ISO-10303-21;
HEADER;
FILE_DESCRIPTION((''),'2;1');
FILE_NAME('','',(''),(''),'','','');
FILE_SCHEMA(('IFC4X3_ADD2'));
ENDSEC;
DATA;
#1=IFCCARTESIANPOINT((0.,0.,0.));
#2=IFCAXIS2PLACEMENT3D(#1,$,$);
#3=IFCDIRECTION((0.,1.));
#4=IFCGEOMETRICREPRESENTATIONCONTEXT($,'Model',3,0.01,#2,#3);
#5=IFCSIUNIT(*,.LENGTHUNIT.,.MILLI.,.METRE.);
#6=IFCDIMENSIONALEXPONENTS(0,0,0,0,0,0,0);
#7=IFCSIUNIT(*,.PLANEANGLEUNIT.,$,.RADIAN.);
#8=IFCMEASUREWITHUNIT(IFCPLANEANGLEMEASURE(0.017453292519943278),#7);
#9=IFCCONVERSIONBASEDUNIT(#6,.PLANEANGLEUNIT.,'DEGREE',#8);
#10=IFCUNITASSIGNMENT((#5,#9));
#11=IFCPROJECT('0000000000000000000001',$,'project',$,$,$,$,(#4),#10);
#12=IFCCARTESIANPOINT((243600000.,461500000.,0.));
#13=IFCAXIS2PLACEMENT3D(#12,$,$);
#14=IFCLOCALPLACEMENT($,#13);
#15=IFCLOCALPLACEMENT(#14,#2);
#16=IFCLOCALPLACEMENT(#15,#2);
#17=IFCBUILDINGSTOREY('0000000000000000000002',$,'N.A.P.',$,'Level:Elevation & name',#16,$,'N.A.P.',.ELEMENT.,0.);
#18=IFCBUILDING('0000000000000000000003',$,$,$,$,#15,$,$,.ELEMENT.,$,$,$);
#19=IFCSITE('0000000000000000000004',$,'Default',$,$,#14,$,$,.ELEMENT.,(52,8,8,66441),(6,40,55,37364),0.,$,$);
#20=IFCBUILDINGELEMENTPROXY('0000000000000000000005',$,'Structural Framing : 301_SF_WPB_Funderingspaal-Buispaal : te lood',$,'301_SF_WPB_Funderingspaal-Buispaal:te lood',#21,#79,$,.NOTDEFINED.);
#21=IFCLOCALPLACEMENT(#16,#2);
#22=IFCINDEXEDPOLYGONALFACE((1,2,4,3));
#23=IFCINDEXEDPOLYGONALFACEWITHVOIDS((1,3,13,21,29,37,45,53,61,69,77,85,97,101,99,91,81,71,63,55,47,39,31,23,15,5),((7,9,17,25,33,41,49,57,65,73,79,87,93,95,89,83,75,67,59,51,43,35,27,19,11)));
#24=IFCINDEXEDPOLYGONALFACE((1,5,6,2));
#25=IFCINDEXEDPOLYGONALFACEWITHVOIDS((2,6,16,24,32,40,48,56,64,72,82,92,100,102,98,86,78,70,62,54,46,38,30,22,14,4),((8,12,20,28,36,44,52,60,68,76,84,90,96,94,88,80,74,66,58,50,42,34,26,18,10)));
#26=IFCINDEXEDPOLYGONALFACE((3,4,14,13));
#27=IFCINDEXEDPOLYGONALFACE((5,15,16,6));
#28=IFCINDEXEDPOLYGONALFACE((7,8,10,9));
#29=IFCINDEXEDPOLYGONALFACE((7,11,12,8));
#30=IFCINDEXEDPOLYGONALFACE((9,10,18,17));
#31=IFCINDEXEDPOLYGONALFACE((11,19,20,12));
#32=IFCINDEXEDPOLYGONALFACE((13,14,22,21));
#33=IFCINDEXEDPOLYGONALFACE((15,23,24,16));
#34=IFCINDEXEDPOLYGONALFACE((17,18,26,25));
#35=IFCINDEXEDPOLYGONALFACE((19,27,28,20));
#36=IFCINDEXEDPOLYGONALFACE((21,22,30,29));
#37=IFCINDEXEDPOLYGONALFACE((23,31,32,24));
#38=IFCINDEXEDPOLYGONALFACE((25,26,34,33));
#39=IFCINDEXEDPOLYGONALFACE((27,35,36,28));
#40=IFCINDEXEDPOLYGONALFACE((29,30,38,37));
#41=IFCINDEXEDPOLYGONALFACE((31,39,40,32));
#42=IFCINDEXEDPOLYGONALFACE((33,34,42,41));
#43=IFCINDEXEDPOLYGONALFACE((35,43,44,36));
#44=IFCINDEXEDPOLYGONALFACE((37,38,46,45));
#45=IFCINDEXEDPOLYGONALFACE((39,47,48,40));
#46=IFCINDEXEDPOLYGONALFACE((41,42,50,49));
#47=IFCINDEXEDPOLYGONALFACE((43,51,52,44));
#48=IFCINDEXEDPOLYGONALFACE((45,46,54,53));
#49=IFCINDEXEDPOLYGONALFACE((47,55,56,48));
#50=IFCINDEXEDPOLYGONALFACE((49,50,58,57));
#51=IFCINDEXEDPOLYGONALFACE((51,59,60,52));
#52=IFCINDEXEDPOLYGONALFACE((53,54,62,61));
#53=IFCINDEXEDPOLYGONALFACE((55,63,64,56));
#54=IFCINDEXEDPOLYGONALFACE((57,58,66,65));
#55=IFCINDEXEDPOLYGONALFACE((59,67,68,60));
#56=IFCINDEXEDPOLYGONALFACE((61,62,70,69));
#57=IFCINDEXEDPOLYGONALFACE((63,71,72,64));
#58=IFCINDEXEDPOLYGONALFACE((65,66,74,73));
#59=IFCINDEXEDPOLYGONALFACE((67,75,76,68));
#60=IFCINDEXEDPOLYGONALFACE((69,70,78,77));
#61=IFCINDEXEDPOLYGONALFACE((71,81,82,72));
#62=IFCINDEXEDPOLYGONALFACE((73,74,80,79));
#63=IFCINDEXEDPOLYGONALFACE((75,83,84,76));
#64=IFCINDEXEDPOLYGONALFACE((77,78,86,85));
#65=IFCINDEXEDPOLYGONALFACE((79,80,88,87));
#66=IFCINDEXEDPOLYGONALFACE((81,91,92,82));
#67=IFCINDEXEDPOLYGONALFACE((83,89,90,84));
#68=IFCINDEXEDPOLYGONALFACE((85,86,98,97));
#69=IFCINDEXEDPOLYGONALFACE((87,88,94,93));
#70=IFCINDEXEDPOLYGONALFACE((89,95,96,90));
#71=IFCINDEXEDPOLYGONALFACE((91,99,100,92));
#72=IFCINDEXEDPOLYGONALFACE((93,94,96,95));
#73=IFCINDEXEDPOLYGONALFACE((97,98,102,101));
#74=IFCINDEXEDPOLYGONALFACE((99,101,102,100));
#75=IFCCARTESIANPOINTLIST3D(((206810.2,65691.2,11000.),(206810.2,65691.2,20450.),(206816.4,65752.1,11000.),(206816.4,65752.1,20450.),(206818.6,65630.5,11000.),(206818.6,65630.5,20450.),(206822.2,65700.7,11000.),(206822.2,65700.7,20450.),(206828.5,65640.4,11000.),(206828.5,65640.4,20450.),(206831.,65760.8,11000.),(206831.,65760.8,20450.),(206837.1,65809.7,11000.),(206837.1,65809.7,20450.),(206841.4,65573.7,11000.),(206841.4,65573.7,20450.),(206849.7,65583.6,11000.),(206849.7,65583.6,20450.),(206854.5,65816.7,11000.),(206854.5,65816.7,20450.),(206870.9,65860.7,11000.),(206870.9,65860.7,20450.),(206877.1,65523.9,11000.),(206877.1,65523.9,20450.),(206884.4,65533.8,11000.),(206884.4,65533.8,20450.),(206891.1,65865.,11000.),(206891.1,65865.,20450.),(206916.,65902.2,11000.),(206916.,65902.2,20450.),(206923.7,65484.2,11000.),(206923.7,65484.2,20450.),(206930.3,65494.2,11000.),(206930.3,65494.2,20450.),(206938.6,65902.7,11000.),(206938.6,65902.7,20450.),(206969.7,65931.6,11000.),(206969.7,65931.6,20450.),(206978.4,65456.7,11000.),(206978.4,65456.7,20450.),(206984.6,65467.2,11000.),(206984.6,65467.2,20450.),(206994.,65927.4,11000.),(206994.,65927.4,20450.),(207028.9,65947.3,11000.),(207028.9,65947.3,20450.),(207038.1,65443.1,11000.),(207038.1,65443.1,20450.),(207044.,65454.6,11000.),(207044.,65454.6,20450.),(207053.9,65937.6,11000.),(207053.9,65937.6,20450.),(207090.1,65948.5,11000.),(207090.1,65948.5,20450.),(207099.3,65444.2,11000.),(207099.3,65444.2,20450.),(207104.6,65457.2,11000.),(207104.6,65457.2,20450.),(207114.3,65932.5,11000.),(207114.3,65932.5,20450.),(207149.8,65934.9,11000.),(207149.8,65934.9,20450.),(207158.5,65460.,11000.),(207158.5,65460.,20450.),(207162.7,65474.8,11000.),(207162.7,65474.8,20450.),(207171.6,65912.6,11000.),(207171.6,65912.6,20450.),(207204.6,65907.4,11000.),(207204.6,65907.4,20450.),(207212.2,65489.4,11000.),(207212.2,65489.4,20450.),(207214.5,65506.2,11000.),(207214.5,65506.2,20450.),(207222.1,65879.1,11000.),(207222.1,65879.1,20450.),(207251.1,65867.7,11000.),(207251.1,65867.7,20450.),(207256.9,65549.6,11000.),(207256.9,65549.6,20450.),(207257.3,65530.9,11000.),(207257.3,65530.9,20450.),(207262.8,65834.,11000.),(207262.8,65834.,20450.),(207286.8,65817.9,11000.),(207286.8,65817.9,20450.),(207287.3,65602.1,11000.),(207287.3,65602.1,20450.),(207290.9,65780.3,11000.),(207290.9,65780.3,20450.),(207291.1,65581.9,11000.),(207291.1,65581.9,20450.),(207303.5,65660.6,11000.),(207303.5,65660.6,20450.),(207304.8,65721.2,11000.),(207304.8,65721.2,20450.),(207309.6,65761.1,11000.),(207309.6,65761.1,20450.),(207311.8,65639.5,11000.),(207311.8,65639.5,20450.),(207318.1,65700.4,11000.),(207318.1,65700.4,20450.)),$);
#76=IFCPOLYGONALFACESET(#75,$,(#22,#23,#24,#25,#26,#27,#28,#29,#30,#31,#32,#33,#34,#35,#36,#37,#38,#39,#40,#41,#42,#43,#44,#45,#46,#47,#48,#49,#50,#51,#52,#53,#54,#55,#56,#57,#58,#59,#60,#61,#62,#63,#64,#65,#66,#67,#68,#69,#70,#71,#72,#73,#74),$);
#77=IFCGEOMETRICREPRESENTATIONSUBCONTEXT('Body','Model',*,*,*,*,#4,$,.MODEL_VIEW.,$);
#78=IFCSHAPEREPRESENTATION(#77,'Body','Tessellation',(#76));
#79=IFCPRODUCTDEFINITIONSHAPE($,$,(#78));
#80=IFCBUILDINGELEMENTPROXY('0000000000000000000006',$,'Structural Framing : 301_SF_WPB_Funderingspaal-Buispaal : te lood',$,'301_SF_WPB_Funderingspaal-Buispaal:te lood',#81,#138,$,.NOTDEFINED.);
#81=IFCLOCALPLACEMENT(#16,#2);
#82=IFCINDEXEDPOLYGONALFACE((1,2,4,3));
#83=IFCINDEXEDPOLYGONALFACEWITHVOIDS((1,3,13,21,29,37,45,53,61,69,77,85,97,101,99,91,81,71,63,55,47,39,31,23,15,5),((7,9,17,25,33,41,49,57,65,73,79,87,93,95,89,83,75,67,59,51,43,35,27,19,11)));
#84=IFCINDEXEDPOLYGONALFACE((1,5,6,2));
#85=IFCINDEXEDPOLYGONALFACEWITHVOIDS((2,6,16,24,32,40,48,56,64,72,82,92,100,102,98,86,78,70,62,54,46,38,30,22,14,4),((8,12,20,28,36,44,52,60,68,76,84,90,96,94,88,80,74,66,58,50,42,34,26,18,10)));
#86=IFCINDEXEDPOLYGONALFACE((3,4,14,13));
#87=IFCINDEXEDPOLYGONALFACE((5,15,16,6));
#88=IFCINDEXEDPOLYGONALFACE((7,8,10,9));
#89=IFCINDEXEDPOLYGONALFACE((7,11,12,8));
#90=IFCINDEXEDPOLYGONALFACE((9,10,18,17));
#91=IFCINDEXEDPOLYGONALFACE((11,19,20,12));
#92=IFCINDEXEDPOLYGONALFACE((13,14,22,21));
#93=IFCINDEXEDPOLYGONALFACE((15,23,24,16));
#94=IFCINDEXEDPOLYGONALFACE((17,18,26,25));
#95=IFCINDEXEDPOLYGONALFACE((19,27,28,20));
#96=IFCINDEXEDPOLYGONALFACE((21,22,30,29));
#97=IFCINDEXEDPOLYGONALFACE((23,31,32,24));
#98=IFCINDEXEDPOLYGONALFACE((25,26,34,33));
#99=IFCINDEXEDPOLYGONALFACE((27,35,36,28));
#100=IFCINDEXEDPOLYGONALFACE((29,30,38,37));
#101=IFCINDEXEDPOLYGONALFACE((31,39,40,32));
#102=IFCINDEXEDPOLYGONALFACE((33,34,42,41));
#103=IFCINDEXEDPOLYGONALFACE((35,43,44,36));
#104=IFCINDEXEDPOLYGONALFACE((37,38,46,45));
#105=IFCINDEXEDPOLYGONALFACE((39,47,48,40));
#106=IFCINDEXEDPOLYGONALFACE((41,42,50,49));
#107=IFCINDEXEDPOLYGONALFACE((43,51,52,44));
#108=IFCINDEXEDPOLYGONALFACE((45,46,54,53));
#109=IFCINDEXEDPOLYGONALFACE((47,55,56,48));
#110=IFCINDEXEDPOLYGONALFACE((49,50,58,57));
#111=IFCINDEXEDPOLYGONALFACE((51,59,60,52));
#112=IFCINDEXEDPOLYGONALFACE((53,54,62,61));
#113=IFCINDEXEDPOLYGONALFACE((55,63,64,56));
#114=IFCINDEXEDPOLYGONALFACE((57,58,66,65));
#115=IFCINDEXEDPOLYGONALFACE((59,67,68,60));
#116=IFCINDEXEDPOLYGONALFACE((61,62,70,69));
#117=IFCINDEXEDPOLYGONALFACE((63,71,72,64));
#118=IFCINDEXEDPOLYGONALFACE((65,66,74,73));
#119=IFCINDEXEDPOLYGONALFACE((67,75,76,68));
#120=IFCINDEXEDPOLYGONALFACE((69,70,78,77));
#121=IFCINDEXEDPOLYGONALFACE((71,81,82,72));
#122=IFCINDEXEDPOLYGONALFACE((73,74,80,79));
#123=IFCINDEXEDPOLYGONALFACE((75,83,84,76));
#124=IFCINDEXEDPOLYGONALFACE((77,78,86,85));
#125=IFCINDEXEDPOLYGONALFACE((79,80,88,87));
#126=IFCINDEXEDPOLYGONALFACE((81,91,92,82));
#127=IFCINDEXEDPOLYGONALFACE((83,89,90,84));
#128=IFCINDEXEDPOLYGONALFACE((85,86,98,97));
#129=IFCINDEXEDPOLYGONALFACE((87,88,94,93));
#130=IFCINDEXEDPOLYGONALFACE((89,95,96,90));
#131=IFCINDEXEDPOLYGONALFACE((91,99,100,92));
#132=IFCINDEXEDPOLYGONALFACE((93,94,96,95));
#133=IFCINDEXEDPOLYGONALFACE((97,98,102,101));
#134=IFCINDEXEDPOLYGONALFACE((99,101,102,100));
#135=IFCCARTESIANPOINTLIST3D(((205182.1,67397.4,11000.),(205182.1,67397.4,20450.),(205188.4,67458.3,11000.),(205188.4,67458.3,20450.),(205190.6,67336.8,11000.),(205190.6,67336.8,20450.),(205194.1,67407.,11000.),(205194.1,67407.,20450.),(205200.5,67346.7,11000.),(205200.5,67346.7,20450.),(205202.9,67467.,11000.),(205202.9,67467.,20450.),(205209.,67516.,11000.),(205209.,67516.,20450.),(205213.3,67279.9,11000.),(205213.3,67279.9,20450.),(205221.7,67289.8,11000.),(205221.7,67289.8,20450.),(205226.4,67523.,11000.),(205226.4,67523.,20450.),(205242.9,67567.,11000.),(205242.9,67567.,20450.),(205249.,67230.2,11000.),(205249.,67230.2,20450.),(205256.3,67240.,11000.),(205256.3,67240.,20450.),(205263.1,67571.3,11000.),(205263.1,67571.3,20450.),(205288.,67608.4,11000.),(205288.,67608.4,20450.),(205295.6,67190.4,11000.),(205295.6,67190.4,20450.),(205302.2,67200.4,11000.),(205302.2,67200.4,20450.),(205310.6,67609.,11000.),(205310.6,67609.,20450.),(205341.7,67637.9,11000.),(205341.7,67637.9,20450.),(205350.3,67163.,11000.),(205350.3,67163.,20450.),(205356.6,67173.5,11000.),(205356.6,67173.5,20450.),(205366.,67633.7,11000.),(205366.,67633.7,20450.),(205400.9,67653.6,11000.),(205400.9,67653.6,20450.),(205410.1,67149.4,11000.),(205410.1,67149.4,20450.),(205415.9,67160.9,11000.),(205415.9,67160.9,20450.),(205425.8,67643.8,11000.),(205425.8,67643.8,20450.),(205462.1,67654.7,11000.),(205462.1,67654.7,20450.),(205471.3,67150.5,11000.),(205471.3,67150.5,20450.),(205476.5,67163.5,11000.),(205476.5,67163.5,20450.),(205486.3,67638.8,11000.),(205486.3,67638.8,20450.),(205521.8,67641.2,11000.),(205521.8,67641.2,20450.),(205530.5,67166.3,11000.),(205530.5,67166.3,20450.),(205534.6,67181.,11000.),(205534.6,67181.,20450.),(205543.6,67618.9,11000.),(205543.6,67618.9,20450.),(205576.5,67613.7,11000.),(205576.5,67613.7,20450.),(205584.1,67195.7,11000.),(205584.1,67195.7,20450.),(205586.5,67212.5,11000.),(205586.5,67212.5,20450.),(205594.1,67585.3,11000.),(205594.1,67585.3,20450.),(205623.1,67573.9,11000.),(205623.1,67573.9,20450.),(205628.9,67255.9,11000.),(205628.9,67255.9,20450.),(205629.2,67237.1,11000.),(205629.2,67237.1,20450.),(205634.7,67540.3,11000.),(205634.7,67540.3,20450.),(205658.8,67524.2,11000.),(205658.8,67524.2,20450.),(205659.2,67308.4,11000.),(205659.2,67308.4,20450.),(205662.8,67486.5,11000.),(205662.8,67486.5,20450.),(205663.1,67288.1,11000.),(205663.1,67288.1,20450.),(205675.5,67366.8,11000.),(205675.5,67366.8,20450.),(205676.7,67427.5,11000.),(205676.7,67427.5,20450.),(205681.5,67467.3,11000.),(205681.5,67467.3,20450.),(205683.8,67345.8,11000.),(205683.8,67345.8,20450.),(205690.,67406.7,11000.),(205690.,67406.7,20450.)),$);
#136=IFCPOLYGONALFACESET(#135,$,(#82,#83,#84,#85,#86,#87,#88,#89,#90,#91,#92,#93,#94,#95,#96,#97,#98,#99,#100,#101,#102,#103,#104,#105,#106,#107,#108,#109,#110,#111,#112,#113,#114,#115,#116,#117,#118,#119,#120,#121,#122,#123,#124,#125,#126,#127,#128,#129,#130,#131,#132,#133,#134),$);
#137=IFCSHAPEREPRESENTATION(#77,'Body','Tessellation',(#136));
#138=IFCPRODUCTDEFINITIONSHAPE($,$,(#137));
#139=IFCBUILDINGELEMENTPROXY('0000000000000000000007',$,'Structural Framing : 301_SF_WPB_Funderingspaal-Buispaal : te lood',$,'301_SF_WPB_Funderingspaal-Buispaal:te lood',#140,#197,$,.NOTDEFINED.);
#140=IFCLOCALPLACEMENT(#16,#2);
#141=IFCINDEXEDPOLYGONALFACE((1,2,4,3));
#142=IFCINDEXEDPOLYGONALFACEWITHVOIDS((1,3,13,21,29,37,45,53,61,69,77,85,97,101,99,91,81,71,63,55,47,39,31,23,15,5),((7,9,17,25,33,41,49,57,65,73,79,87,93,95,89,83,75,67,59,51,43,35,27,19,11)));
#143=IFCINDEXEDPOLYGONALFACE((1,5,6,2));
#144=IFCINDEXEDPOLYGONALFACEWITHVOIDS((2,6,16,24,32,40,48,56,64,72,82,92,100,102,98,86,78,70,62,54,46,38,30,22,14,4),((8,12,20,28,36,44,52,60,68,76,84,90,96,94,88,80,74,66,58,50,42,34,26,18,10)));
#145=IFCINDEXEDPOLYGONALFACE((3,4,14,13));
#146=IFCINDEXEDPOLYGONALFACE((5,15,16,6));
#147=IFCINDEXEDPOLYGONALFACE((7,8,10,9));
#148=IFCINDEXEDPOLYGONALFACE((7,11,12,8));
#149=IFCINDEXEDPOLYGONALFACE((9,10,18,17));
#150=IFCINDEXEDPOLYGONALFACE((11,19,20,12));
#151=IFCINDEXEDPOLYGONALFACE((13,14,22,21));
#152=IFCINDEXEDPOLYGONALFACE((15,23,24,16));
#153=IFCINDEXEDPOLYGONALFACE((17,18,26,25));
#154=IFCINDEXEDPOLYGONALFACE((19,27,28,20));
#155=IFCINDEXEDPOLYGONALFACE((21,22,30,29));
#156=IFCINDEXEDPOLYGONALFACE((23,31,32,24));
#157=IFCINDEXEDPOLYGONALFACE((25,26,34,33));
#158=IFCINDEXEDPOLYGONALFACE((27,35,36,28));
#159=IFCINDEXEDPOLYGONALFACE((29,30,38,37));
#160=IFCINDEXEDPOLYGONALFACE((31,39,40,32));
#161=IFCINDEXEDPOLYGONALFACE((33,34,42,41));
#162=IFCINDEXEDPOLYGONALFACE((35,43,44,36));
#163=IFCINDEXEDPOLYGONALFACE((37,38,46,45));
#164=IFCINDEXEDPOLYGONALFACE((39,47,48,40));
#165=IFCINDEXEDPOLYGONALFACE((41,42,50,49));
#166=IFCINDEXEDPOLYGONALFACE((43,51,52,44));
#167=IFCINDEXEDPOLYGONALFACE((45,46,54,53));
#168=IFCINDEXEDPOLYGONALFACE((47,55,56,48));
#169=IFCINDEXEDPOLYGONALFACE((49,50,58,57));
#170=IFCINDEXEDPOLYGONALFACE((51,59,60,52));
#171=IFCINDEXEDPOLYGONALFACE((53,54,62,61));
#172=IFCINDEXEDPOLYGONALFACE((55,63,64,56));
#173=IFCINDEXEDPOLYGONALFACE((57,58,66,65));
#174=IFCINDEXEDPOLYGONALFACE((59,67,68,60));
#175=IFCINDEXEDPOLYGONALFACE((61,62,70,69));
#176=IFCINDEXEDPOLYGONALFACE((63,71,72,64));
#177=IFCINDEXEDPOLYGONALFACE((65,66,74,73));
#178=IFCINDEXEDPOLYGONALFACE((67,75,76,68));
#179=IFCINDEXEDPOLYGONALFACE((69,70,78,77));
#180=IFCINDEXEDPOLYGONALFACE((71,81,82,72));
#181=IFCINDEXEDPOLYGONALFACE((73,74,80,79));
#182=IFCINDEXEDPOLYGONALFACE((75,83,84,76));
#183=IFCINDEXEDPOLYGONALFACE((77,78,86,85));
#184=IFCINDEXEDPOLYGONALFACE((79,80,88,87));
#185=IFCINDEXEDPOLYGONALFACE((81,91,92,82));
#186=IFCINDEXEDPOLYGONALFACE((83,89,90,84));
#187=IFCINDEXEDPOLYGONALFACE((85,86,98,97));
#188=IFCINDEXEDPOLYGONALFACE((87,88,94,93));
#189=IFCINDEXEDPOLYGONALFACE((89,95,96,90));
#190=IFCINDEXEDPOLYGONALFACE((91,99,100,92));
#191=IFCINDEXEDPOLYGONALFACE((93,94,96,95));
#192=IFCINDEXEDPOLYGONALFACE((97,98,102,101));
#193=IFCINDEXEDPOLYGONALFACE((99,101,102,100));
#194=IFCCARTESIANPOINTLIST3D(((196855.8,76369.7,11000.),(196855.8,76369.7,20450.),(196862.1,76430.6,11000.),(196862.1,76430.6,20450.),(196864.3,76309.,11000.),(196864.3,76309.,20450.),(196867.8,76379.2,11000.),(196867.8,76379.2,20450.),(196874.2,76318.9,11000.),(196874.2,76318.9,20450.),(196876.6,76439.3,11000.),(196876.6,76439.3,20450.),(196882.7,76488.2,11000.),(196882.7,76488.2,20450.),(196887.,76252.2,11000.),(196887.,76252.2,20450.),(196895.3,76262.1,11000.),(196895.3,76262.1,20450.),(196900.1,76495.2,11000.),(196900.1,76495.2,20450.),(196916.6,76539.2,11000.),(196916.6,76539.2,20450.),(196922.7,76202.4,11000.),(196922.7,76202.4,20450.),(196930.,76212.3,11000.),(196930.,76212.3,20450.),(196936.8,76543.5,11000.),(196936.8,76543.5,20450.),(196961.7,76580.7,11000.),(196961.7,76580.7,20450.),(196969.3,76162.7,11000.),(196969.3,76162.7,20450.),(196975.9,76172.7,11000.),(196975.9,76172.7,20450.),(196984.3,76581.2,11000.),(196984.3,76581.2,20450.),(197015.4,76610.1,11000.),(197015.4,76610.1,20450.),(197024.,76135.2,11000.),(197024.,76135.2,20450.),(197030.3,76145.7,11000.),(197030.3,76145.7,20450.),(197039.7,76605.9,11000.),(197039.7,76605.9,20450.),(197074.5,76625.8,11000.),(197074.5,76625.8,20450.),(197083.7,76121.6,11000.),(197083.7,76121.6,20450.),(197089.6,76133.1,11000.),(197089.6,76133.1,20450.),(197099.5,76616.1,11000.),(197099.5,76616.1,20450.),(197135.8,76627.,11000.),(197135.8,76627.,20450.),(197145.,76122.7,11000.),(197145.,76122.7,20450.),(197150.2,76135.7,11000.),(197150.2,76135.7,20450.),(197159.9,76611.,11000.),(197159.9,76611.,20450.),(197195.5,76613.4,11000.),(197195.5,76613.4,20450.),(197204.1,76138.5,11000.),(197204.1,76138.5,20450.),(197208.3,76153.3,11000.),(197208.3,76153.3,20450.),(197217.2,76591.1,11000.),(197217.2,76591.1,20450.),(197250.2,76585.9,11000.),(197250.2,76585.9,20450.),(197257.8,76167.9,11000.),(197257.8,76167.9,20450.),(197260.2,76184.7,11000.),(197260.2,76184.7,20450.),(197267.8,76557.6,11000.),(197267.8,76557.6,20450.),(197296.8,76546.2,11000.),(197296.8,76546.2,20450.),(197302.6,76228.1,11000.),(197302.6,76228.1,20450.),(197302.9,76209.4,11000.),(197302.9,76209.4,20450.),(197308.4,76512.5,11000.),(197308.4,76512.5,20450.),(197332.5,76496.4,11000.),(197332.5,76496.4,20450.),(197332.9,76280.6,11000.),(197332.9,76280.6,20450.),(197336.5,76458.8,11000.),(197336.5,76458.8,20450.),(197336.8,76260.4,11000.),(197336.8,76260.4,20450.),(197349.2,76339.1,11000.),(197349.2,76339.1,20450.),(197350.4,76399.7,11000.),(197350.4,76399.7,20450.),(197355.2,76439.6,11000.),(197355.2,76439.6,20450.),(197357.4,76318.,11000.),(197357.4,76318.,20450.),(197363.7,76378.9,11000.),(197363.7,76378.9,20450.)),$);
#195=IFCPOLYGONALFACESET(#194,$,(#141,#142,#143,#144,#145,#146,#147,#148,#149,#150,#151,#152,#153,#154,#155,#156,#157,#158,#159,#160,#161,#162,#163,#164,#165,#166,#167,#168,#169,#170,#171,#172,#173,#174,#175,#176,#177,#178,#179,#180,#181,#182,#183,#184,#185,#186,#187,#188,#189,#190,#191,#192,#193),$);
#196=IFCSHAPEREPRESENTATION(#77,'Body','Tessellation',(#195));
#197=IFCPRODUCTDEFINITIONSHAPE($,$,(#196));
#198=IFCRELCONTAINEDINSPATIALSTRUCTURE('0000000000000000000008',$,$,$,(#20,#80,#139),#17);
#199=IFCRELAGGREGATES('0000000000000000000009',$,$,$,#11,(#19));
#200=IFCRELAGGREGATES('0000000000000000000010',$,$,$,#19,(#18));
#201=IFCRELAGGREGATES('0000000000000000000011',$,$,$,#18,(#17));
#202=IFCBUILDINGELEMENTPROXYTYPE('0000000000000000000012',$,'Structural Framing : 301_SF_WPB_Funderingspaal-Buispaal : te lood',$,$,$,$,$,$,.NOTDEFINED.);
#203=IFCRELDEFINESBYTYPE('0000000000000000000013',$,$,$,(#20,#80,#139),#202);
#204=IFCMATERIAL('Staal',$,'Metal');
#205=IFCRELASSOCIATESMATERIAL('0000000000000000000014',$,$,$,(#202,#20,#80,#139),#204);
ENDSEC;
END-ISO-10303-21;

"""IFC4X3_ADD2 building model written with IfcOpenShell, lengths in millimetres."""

from ifc_helpers import new_model, entity, si_unit, converted_unit, direction, frame, frame_2d, origin, place, context, subcontext, project, spatial, hollow_circle, extrude, source, transform, mapped, material, type_object, type_shapes, element, save


model = new_model("IFC4X3_ADD2")

# Units and contexts
model_context = context("Model", 3, precision=0.01, world=origin(), true_north=direction((0.0, 1.0)))
body_context = subcontext(model_context, "Body", "Model", "MODEL_VIEW")
ifc_project = project(units=[si_unit("LENGTHUNIT", "METRE", prefix="MILLI"), converted_unit("PLANEANGLEUNIT", "DEGREE", entity("IfcPlaneAngleMeasure", 0.017453292519943278), si_unit("PLANEANGLEUNIT", "RADIAN"), dimensions=[0, 0, 0, 0, 0, 0, 0])], contexts=[model_context])

# Site, building, storey
site_placement = place(None, frame((243600000.0, 461500000.0, 0.0)))
site = spatial("IfcSite", under=ifc_project, at=site_placement, Name="Default", CompositionType="ELEMENT", RefLatitude=(52, 8, 8, 66441), RefLongitude=(6, 40, 55, 37364), RefElevation=0.0)
building_placement = place(site_placement, origin())
building = spatial("IfcBuilding", under=site, at=building_placement, CompositionType="ELEMENT")
storey_placement = place(building_placement, origin())
storey = spatial("IfcBuildingStorey", under=building, at=storey_placement, Name="N.A.P.", ObjectType="Level:Elevation & name", LongName="N.A.P.", CompositionType="ELEMENT", Elevation=0.0)

# Building element proxies
ifc_material_1 = material(Name="Staal", Category="Metal")
building_element_proxy_type_1 = type_object("IfcBuildingElementProxyType", Name="Structural Framing : 301_SF_WPB_Funderingspaal-Buispaal : te lood", PredefinedType="NOTDEFINED", material=ifc_material_1)
shared_shape_1 = source(origin(), body_context, "Body", "SweptSolid", [
    extrude(hollow_circle(Radius=254.0, WallThickness=12.0, at=frame_2d((0.0, 0.0), x_axis=(1.0, 0.0))), frame((0.0, 0.0, 11000.0), z_axis=(0.0, 0.0, 1.0), x_axis=(0.0, -1.0, 0.0)), (0.0, 0.0, 1.0), 9450.0),
])
type_shapes(building_element_proxy_type_1, [shared_shape_1])
for number, where, z_axis, x_axis, name in (
    (1, (207064.1, 65695.8, 0.0), (0.0, 0.0, 1.0), (0.833209, -0.552959, 0.0), "Structural Framing : 301_SF_WPB_Funderingspaal-Buispaal : te lood"),
    (2, (205436.1, 67402.1, 0.0), (0.0, 0.0, 1.0), (0.833209, -0.552959, 0.0), "Structural Framing : 301_SF_WPB_Funderingspaal-Buispaal : te lood"),
    (3, (197109.7, 76374.3, 0.0), (0.0, 0.0, 1.0), (0.833209, -0.552959, 0.0), "Structural Framing : 301_SF_WPB_Funderingspaal-Buispaal : te lood"),
):
    element("IfcBuildingElementProxy", number, at=place(storey_placement, frame(where, z_axis=z_axis, x_axis=x_axis)), inside=storey, type_object=building_element_proxy_type_1, material=ifc_material_1, Name=name, ObjectType="301_SF_WPB_Funderingspaal-Buispaal:te lood", PredefinedType="NOTDEFINED", context=body_context, shape_type="MappedRepresentation", body=[
        mapped(shared_shape_1, transform((0.0, 0.0, 0.0), scale=1.0)),
    ])

save(model, "model.ifc")
